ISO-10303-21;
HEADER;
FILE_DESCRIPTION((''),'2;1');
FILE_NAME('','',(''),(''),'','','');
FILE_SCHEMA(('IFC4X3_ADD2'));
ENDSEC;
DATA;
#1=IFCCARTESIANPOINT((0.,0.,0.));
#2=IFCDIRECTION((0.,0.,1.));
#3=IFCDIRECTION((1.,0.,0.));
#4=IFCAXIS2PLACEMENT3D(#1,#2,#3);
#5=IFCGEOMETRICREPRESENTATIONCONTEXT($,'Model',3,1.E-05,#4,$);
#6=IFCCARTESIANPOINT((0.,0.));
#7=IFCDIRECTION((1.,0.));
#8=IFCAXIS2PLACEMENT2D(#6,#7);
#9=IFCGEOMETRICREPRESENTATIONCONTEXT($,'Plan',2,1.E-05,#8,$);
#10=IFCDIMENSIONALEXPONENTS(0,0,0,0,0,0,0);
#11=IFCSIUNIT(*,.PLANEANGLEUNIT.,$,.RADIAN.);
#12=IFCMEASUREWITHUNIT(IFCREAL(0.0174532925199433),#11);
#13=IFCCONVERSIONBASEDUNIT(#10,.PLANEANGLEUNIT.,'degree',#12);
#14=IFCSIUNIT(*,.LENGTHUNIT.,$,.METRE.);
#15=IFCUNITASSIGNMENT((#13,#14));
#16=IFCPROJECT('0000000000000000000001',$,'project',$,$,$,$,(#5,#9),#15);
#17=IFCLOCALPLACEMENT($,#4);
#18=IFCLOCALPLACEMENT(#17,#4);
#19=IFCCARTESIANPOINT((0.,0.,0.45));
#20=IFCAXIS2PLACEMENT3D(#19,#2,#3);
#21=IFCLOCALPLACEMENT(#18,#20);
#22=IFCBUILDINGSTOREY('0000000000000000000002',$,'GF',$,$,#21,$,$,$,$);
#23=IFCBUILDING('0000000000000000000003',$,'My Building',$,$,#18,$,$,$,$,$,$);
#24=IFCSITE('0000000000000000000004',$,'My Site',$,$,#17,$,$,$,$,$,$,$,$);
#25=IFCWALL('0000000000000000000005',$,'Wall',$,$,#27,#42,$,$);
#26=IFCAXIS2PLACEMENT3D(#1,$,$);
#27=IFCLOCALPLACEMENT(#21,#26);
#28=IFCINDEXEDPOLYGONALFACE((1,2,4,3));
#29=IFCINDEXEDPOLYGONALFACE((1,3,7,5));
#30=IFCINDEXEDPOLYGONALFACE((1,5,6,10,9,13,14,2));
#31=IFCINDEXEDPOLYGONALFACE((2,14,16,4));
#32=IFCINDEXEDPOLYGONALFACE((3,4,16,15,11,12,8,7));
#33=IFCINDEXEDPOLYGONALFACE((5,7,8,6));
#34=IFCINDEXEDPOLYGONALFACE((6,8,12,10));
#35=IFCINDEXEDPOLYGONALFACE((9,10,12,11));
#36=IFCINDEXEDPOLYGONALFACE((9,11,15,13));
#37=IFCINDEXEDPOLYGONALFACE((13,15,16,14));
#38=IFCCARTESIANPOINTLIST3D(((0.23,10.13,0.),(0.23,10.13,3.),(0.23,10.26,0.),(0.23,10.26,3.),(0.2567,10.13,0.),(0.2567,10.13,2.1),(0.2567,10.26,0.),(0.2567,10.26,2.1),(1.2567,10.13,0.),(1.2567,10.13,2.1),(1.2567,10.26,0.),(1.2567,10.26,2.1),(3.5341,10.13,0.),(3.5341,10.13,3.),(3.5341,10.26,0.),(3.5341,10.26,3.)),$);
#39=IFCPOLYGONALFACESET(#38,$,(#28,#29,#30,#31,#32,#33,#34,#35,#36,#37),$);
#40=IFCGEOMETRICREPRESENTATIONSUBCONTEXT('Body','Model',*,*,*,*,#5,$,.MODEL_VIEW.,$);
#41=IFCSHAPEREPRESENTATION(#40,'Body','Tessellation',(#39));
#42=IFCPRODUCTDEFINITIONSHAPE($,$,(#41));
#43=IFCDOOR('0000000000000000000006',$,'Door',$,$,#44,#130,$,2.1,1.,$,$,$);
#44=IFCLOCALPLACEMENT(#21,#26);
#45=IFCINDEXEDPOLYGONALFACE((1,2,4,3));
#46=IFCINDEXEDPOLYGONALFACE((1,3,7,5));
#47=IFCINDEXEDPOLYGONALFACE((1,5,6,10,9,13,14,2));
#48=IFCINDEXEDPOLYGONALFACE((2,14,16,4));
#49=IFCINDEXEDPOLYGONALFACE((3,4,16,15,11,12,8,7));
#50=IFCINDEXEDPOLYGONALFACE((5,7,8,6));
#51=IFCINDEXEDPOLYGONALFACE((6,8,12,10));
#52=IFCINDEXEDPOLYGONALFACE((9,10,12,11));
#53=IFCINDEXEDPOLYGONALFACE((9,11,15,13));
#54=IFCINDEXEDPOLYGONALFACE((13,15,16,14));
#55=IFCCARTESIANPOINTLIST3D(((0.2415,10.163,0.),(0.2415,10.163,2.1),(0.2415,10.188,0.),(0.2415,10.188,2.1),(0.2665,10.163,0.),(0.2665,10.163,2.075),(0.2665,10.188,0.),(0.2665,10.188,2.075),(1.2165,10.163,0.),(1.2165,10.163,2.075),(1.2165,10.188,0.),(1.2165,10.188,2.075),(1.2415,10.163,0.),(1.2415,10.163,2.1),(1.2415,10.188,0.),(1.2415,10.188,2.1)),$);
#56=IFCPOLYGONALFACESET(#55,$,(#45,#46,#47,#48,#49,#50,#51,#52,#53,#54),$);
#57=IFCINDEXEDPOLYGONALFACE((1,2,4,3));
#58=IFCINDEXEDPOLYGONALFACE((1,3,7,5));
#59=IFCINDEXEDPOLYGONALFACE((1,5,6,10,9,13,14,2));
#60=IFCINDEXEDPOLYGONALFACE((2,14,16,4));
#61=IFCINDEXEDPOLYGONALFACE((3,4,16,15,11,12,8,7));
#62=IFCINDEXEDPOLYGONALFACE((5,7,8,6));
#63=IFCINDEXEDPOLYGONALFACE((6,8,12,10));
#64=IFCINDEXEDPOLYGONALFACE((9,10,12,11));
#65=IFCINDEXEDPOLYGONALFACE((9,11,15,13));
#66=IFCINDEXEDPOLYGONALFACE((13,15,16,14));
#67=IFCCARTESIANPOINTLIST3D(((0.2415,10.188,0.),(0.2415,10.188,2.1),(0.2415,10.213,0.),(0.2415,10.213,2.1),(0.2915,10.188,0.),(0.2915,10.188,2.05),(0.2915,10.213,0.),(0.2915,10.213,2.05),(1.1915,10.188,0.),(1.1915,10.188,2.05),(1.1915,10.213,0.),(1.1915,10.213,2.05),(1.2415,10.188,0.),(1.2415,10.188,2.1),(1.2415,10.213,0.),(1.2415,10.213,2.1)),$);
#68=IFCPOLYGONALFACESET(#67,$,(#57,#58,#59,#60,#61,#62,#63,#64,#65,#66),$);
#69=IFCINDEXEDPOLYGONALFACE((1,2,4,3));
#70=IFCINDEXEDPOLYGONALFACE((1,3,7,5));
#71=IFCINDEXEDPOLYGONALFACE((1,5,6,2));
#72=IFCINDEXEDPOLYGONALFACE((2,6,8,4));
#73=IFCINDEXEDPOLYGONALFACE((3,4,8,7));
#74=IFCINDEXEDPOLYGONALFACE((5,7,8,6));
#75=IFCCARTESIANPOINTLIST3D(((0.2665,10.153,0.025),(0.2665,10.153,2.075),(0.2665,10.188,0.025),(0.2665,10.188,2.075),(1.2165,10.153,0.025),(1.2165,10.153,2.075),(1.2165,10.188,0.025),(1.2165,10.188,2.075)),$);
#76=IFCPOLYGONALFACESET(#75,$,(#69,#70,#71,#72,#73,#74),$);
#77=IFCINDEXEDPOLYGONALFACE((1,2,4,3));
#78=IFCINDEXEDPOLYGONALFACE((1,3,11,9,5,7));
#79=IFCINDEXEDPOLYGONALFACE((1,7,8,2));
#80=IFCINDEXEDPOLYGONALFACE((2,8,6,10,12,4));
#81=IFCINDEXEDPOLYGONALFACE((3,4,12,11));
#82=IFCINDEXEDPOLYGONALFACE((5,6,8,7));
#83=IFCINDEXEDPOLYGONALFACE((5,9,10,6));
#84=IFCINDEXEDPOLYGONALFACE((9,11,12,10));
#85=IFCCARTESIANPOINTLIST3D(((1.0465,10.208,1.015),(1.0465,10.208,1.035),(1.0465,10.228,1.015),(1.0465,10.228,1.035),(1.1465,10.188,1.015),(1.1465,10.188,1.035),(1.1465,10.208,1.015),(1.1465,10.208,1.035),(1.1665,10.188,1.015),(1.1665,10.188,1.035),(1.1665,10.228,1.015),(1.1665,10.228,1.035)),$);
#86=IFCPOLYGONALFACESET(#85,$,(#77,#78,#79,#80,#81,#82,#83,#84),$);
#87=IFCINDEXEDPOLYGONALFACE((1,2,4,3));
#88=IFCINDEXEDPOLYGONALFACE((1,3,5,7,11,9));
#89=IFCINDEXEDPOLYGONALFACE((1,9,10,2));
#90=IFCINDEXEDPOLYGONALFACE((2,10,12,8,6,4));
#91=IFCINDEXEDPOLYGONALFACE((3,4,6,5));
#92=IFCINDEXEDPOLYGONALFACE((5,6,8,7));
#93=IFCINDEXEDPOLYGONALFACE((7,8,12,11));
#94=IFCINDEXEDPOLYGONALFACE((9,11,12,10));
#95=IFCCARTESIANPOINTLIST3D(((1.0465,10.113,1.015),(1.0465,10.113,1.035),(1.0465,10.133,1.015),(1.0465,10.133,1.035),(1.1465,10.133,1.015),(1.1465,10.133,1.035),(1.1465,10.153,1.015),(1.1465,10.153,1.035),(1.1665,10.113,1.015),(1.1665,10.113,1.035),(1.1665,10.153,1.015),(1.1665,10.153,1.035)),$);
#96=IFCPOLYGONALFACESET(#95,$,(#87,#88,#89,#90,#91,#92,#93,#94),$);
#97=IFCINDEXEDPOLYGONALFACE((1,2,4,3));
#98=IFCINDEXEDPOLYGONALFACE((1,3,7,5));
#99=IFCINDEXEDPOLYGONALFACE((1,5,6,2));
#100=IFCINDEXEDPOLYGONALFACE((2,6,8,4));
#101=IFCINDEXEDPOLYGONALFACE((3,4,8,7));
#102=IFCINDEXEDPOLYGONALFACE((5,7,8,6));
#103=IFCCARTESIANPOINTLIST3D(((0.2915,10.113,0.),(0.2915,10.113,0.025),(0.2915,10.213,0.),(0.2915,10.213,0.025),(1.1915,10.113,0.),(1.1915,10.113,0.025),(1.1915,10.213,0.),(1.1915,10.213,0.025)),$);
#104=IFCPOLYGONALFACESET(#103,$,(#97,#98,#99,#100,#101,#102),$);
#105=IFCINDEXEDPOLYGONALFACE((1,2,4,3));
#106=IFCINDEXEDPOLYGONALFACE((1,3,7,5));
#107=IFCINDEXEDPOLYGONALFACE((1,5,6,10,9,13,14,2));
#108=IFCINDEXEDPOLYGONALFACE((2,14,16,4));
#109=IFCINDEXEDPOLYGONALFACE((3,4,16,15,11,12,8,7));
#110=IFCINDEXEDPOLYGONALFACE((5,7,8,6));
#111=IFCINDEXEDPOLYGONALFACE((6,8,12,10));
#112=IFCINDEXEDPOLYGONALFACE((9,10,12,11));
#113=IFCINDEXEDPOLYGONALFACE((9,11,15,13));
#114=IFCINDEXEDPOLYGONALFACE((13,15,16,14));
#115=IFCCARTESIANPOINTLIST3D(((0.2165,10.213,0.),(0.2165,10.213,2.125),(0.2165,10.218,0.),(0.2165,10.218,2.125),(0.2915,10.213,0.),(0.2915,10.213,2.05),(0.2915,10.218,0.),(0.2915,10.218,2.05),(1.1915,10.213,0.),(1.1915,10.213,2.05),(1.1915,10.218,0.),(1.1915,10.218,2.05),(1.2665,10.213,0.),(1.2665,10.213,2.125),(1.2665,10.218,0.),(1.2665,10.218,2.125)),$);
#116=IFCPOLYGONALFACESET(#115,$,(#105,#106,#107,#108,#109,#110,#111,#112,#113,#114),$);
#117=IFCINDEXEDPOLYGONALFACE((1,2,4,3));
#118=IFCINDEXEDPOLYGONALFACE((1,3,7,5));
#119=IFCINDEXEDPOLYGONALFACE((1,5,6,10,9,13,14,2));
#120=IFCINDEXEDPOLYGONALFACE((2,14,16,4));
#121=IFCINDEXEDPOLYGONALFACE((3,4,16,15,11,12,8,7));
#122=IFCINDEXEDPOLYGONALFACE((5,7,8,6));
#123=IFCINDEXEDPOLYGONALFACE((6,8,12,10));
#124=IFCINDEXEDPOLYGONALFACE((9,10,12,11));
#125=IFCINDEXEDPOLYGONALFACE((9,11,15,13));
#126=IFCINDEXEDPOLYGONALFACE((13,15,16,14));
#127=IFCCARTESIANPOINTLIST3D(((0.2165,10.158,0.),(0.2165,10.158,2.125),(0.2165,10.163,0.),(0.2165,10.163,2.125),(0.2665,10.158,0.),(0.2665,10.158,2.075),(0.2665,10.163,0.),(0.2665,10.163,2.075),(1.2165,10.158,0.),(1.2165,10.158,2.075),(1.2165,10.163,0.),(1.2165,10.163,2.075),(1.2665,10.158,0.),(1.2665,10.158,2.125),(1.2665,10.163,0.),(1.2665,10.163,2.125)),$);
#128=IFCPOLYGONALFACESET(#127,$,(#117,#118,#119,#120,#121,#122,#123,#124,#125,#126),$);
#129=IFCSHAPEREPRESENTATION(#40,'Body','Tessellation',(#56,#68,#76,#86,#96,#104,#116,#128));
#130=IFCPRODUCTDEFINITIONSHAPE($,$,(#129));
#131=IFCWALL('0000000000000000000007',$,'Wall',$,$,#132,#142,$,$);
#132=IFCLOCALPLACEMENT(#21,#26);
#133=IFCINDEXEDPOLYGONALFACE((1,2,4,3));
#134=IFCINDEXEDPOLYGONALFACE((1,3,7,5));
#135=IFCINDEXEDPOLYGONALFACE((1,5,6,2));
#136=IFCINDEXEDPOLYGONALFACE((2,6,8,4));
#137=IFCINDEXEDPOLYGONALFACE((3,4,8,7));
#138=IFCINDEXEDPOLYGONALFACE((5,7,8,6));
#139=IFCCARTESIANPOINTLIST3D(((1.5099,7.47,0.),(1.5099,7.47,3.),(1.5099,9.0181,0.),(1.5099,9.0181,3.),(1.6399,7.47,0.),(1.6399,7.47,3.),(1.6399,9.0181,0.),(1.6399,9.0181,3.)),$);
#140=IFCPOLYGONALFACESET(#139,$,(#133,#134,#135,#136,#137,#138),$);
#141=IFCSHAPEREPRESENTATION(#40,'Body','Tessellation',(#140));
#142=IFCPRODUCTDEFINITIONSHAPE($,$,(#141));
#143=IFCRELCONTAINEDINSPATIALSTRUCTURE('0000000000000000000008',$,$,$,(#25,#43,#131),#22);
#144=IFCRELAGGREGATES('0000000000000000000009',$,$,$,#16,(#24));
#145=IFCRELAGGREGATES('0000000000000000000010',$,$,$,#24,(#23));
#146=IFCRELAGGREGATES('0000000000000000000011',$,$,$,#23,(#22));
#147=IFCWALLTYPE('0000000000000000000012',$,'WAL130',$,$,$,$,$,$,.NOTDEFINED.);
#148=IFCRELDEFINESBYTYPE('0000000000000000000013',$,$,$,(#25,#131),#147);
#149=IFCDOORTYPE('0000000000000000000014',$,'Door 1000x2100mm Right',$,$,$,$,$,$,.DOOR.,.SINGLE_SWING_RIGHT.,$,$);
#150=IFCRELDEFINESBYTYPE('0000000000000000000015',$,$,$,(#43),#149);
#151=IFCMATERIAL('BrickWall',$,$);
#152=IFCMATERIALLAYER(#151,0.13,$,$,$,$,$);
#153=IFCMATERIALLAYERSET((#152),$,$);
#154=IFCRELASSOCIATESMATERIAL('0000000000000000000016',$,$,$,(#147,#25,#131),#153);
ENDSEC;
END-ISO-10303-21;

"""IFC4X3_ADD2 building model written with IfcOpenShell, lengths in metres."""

from ifc_helpers import new_model, entity, si_unit, converted_unit, frame, origin_with_axes, origin_2d_with_axis, place, context, subcontext, project, spatial, line, indexed_curve, outline, extrude, shape, source, transform, mapped, material, layer, layer_set, layer_usage, type_object, type_shapes, element, fill, save


model = new_model("IFC4X3_ADD2")

# Units and contexts
model_context = context("Model", 3, precision=1e-05, world=origin_with_axes())
plan_context = context("Plan", 2, precision=1e-05, world=origin_2d_with_axis())
body_context_1 = subcontext(model_context, "Body", "Model", "MODEL_VIEW")
body_context_2 = subcontext(plan_context, "Body", "Plan", "PLAN_VIEW")
ifc_project = project(units=[converted_unit("PLANEANGLEUNIT", "degree", entity("IfcReal", 0.0174532925199433), si_unit("PLANEANGLEUNIT", "RADIAN"), dimensions=[0, 0, 0, 0, 0, 0, 0]), si_unit("LENGTHUNIT", "METRE")], contexts=[model_context, plan_context])

# Site, building, storey
site_placement = place(None, origin_with_axes())
site = spatial("IfcSite", under=ifc_project, at=site_placement, Name="My Site")
building_placement = place(site_placement, origin_with_axes())
building = spatial("IfcBuilding", under=site, at=building_placement, Name="My Building")
storey_placement = place(building_placement, frame((0.0, 0.0, 0.45), z_axis=(0.0, 0.0, 1.0), x_axis=(1.0, 0.0, 0.0)))
storey = spatial("IfcBuildingStorey", under=building, at=storey_placement, Name="GF")

# Shared definitions
ifc_material_1 = material(Name="BrickWall")
shared_shape_1 = source(origin_with_axes(), body_context_1, "Body", "SweptSolid", [
    extrude(outline(indexed_curve([(0.0, 0.0), (1.0, 0.0), (1.0, 2.1), (0.0, 2.1)], segments=[line(1, 2, 3, 4, 1)])), frame((0.0, -0.6, 0.0), z_axis=(0.0, -1.0, 0.0), x_axis=(1.0, 0.0, 0.0)), (0.0, 0.0, -1.0), 1.2),
])
door_type_1 = type_object("IfcDoorType", Name="Door 1000x2100mm Right", OperationType="SINGLE_SWING_RIGHT", PredefinedType="DOOR")
shared_shape_2 = source(origin_with_axes(), body_context_1, "Body", "SweptSolid", [
    extrude(outline(indexed_curve([(0.0, 0.0), (0.0, 2.1), (1.0, 2.1), (1.0, 0.0), (0.975, 0.0), (0.975, 2.075), (0.025, 2.075), (0.025, 0.0)], segments=[line(1, 2, 3, 4, 5, 6, 7, 8, 1)])), frame((0.0, 0.025, 0.0), z_axis=(0.0, -1.0, 0.0), x_axis=(1.0, 0.0, 0.0)), (0.0, 0.0, -1.0), 0.025),
    extrude(outline(indexed_curve([(0.0, 0.0), (0.0, 2.1), (1.0, 2.1), (1.0, 0.0), (0.95, 0.0), (0.95, 2.05), (0.05, 2.05), (0.05, 0.0)], segments=[line(1, 2, 3, 4, 5, 6, 7, 8, 1)])), frame((0.0, 0.0, 0.0), z_axis=(0.0, -1.0, 0.0), x_axis=(1.0, 0.0, 0.0)), (0.0, 0.0, -1.0), 0.025),
    extrude(outline(indexed_curve([(0.0, 0.0), (0.95, 0.0), (0.95, 0.035), (0.0, 0.035)], segments=[line(1, 2, 3, 4, 1)])), frame((0.025, 0.025, 0.025), z_axis=(0.0, 0.0, 1.0), x_axis=(1.0, 0.0, 0.0)), (0.0, 0.0, 1.0), 2.05),
    extrude(outline(indexed_curve([(0.0, 0.0), (0.0, -0.04), (0.12, -0.04), (0.12, -0.02), (0.02, -0.02), (0.02, 0.0)], segments=[line(1, 2, 3, 4, 5, 6, 1)])), frame((0.075, 0.025, 1.015), z_axis=(0.0, 0.0, 1.0), x_axis=(1.0, 0.0, 0.0)), (0.0, 0.0, 1.0), 0.02),
    extrude(outline(indexed_curve([(0.0, 0.0), (0.0, 0.04), (0.12, 0.04), (0.12, 0.02), (0.02, 0.02), (0.02, 0.0)], segments=[line(1, 2, 3, 4, 5, 6, 1)])), frame((0.075, 0.06, 1.015), z_axis=(0.0, 0.0, 1.0), x_axis=(1.0, 0.0, 0.0)), (0.0, 0.0, 1.0), 0.02),
    extrude(outline(indexed_curve([(0.0, 0.0), (0.9, 0.0), (0.9, 0.1), (0.0, 0.1)], segments=[line(1, 2, 3, 4, 1)])), frame((0.05, 0.0, 0.0), z_axis=(0.0, 0.0, 1.0), x_axis=(1.0, 0.0, 0.0)), (0.0, 0.0, 1.0), 0.025),
    extrude(outline(indexed_curve([(0.0, 0.0), (0.0, 2.125), (1.05, 2.125), (1.05, 0.0), (0.975, 0.0), (0.975, 2.05), (0.075, 2.05), (0.075, 0.0)], segments=[line(1, 2, 3, 4, 5, 6, 7, 8, 1)])), frame((-0.025, -0.005, 0.0), z_axis=(0.0, -1.0, 0.0), x_axis=(1.0, 0.0, 0.0)), (0.0, 0.0, -1.0), 0.005),
    extrude(outline(indexed_curve([(0.0, 0.0), (0.0, 2.125), (1.05, 2.125), (1.05, 0.0), (1.0, 0.0), (1.0, 2.075), (0.05, 2.075), (0.05, 0.0)], segments=[line(1, 2, 3, 4, 5, 6, 7, 8, 1)])), frame((-0.025, 0.05, 0.0), z_axis=(0.0, -1.0, 0.0), x_axis=(1.0, 0.0, 0.0)), (0.0, 0.0, -1.0), 0.005),
])
shared_shape_3 = source(origin_with_axes(), body_context_2, "Body", "Curve2D", [
    entity("IfcIndexedPolyCurve", entity("IfcCartesianPointList2D", [[0.0, 0.0], [0.0, 0.05], [0.025, 0.05], [0.025, 0.025], [0.05, 0.025], [0.05, 0.0]]), [entity("IfcLineIndex", [1, 2, 3, 4, 5, 6, 1])]),
    entity("IfcIndexedPolyCurve", entity("IfcCartesianPointList2D", [[1.0, 0.0], [1.0, 0.05], [0.975, 0.05], [0.975, 0.025], [0.95, 0.025], [0.95, 0.0]]), [entity("IfcLineIndex", [1, 2, 3, 4, 5, 6, 1])]),
    entity("IfcTrimmedCurve", entity("IfcEllipse", entity("IfcAxis2Placement2D", entity("IfcCartesianPoint", [0.94, 0.05]), entity("IfcDirection", [1.0, 0.0])), 0.915, 0.95), [entity("IfcCartesianPoint", [0.94, 1.0])], [entity("IfcCartesianPoint", [0.025, 0.05])], True, "CARTESIAN"),
    entity("IfcIndexedPolyCurve", entity("IfcCartesianPointList2D", [[0.975, 0.05], [0.94, 0.05], [0.94, 1.0], [0.975, 1.0]]), [entity("IfcLineIndex", [1, 2, 3, 4, 1])]),
])
type_shapes(door_type_1, [shared_shape_2, shared_shape_3])

# Wall, opening, door
ifc_layer_1 = layer(ifc_material_1, 0.13)
ifc_layer_set_1 = layer_set([ifc_layer_1])
wall_type_1 = type_object("IfcWallType", Name="WAL130", PredefinedType="NOTDEFINED", material=ifc_layer_set_1)
ifc_layer_usage_1 = layer_usage(ifc_layer_set_1, "AXIS2", "POSITIVE", 0.0)
wall_1_placement = place(storey_placement, frame((0.23, 10.13, 0.0), z_axis=(0.0, 0.0, 1.0), x_axis=(1.0, 0.0, 0.0)))
wall_1 = element("IfcWall", 1, at=wall_1_placement, inside=storey, type_object=wall_type_1, material=ifc_layer_usage_1, Name="Wall", context=body_context_1, shape_type="SweptSolid", body=[
    extrude(outline(indexed_curve([(0.0, 0.0), (0.0, 0.13), (3.3041, 0.13), (3.3041, 0.0), (0.0, 0.0)], self_intersect=False)), origin_with_axes(), (0.0, 0.0, 1.0), 3.0),
])
opening_1_placement = place(wall_1_placement, frame((1.0267, 0.083, 0.0), z_axis=(0.0, 0.0, 1.0), x_axis=(-1.0, 0.0, 0.0)))
opening_1 = element("IfcOpeningElement", 2, at=opening_1_placement, cuts=wall_1, PredefinedType="OPENING", context=body_context_1, shape_type="MappedRepresentation", body=[
    mapped(shared_shape_1, transform((0.0, 0.0, 0.0), x_axis=(1.0, 0.0, 0.0), y_axis=(0.0, 1.0, 0.0), z_axis=(0.0, 0.0, 1.0), scale=1.0)),
])
door_1_placement = place(opening_1_placement, frame((0.0152, 0.0, 0.0), z_axis=(0.0, 0.0, 1.0), x_axis=(1.0, 0.0, 0.0)))
door_1 = element("IfcDoor", 3, at=door_1_placement, inside=storey, type_object=door_type_1, Name="Door", OverallHeight=2.1, OverallWidth=1.0, shapes=[
    shape(body_context_1, "Body", "MappedRepresentation", [mapped(shared_shape_2, transform((0.0, 0.0, 0.0), x_axis=(1.0, 0.0, 0.0), y_axis=(0.0, 1.0, 0.0), z_axis=(0.0, 0.0, 1.0), scale=1.0))]),
    shape(body_context_2, "Body", "MappedRepresentation", [mapped(shared_shape_3, transform((0.0, 0.0, 0.0), x_axis=(1.0, 0.0, 0.0), y_axis=(0.0, 1.0, 0.0), z_axis=(0.0, 0.0, 1.0), scale=1.0))]),
])
fill(opening_1, door_1)

# Wall
ifc_layer_usage_2 = layer_usage(ifc_layer_set_1, "AXIS2", "POSITIVE", 0.0)
wall_2_placement = place(storey_placement, frame((1.6399, 7.47, 0.0), z_axis=(0.0, 0.0, 1.0), x_axis=(0.0, 1.0, 0.0)))
element("IfcWall", 4, at=wall_2_placement, inside=storey, type_object=wall_type_1, material=ifc_layer_usage_2, Name="Wall", context=body_context_1, shape_type="SweptSolid", body=[
    extrude(outline(indexed_curve([(0.0, 0.0), (0.0, 0.13), (1.5481, 0.13), (1.5481, 0.0), (0.0, 0.0)], self_intersect=False)), origin_with_axes(), (0.0, 0.0, 1.0), 3.0),
])

save(model, "model.ifc")
